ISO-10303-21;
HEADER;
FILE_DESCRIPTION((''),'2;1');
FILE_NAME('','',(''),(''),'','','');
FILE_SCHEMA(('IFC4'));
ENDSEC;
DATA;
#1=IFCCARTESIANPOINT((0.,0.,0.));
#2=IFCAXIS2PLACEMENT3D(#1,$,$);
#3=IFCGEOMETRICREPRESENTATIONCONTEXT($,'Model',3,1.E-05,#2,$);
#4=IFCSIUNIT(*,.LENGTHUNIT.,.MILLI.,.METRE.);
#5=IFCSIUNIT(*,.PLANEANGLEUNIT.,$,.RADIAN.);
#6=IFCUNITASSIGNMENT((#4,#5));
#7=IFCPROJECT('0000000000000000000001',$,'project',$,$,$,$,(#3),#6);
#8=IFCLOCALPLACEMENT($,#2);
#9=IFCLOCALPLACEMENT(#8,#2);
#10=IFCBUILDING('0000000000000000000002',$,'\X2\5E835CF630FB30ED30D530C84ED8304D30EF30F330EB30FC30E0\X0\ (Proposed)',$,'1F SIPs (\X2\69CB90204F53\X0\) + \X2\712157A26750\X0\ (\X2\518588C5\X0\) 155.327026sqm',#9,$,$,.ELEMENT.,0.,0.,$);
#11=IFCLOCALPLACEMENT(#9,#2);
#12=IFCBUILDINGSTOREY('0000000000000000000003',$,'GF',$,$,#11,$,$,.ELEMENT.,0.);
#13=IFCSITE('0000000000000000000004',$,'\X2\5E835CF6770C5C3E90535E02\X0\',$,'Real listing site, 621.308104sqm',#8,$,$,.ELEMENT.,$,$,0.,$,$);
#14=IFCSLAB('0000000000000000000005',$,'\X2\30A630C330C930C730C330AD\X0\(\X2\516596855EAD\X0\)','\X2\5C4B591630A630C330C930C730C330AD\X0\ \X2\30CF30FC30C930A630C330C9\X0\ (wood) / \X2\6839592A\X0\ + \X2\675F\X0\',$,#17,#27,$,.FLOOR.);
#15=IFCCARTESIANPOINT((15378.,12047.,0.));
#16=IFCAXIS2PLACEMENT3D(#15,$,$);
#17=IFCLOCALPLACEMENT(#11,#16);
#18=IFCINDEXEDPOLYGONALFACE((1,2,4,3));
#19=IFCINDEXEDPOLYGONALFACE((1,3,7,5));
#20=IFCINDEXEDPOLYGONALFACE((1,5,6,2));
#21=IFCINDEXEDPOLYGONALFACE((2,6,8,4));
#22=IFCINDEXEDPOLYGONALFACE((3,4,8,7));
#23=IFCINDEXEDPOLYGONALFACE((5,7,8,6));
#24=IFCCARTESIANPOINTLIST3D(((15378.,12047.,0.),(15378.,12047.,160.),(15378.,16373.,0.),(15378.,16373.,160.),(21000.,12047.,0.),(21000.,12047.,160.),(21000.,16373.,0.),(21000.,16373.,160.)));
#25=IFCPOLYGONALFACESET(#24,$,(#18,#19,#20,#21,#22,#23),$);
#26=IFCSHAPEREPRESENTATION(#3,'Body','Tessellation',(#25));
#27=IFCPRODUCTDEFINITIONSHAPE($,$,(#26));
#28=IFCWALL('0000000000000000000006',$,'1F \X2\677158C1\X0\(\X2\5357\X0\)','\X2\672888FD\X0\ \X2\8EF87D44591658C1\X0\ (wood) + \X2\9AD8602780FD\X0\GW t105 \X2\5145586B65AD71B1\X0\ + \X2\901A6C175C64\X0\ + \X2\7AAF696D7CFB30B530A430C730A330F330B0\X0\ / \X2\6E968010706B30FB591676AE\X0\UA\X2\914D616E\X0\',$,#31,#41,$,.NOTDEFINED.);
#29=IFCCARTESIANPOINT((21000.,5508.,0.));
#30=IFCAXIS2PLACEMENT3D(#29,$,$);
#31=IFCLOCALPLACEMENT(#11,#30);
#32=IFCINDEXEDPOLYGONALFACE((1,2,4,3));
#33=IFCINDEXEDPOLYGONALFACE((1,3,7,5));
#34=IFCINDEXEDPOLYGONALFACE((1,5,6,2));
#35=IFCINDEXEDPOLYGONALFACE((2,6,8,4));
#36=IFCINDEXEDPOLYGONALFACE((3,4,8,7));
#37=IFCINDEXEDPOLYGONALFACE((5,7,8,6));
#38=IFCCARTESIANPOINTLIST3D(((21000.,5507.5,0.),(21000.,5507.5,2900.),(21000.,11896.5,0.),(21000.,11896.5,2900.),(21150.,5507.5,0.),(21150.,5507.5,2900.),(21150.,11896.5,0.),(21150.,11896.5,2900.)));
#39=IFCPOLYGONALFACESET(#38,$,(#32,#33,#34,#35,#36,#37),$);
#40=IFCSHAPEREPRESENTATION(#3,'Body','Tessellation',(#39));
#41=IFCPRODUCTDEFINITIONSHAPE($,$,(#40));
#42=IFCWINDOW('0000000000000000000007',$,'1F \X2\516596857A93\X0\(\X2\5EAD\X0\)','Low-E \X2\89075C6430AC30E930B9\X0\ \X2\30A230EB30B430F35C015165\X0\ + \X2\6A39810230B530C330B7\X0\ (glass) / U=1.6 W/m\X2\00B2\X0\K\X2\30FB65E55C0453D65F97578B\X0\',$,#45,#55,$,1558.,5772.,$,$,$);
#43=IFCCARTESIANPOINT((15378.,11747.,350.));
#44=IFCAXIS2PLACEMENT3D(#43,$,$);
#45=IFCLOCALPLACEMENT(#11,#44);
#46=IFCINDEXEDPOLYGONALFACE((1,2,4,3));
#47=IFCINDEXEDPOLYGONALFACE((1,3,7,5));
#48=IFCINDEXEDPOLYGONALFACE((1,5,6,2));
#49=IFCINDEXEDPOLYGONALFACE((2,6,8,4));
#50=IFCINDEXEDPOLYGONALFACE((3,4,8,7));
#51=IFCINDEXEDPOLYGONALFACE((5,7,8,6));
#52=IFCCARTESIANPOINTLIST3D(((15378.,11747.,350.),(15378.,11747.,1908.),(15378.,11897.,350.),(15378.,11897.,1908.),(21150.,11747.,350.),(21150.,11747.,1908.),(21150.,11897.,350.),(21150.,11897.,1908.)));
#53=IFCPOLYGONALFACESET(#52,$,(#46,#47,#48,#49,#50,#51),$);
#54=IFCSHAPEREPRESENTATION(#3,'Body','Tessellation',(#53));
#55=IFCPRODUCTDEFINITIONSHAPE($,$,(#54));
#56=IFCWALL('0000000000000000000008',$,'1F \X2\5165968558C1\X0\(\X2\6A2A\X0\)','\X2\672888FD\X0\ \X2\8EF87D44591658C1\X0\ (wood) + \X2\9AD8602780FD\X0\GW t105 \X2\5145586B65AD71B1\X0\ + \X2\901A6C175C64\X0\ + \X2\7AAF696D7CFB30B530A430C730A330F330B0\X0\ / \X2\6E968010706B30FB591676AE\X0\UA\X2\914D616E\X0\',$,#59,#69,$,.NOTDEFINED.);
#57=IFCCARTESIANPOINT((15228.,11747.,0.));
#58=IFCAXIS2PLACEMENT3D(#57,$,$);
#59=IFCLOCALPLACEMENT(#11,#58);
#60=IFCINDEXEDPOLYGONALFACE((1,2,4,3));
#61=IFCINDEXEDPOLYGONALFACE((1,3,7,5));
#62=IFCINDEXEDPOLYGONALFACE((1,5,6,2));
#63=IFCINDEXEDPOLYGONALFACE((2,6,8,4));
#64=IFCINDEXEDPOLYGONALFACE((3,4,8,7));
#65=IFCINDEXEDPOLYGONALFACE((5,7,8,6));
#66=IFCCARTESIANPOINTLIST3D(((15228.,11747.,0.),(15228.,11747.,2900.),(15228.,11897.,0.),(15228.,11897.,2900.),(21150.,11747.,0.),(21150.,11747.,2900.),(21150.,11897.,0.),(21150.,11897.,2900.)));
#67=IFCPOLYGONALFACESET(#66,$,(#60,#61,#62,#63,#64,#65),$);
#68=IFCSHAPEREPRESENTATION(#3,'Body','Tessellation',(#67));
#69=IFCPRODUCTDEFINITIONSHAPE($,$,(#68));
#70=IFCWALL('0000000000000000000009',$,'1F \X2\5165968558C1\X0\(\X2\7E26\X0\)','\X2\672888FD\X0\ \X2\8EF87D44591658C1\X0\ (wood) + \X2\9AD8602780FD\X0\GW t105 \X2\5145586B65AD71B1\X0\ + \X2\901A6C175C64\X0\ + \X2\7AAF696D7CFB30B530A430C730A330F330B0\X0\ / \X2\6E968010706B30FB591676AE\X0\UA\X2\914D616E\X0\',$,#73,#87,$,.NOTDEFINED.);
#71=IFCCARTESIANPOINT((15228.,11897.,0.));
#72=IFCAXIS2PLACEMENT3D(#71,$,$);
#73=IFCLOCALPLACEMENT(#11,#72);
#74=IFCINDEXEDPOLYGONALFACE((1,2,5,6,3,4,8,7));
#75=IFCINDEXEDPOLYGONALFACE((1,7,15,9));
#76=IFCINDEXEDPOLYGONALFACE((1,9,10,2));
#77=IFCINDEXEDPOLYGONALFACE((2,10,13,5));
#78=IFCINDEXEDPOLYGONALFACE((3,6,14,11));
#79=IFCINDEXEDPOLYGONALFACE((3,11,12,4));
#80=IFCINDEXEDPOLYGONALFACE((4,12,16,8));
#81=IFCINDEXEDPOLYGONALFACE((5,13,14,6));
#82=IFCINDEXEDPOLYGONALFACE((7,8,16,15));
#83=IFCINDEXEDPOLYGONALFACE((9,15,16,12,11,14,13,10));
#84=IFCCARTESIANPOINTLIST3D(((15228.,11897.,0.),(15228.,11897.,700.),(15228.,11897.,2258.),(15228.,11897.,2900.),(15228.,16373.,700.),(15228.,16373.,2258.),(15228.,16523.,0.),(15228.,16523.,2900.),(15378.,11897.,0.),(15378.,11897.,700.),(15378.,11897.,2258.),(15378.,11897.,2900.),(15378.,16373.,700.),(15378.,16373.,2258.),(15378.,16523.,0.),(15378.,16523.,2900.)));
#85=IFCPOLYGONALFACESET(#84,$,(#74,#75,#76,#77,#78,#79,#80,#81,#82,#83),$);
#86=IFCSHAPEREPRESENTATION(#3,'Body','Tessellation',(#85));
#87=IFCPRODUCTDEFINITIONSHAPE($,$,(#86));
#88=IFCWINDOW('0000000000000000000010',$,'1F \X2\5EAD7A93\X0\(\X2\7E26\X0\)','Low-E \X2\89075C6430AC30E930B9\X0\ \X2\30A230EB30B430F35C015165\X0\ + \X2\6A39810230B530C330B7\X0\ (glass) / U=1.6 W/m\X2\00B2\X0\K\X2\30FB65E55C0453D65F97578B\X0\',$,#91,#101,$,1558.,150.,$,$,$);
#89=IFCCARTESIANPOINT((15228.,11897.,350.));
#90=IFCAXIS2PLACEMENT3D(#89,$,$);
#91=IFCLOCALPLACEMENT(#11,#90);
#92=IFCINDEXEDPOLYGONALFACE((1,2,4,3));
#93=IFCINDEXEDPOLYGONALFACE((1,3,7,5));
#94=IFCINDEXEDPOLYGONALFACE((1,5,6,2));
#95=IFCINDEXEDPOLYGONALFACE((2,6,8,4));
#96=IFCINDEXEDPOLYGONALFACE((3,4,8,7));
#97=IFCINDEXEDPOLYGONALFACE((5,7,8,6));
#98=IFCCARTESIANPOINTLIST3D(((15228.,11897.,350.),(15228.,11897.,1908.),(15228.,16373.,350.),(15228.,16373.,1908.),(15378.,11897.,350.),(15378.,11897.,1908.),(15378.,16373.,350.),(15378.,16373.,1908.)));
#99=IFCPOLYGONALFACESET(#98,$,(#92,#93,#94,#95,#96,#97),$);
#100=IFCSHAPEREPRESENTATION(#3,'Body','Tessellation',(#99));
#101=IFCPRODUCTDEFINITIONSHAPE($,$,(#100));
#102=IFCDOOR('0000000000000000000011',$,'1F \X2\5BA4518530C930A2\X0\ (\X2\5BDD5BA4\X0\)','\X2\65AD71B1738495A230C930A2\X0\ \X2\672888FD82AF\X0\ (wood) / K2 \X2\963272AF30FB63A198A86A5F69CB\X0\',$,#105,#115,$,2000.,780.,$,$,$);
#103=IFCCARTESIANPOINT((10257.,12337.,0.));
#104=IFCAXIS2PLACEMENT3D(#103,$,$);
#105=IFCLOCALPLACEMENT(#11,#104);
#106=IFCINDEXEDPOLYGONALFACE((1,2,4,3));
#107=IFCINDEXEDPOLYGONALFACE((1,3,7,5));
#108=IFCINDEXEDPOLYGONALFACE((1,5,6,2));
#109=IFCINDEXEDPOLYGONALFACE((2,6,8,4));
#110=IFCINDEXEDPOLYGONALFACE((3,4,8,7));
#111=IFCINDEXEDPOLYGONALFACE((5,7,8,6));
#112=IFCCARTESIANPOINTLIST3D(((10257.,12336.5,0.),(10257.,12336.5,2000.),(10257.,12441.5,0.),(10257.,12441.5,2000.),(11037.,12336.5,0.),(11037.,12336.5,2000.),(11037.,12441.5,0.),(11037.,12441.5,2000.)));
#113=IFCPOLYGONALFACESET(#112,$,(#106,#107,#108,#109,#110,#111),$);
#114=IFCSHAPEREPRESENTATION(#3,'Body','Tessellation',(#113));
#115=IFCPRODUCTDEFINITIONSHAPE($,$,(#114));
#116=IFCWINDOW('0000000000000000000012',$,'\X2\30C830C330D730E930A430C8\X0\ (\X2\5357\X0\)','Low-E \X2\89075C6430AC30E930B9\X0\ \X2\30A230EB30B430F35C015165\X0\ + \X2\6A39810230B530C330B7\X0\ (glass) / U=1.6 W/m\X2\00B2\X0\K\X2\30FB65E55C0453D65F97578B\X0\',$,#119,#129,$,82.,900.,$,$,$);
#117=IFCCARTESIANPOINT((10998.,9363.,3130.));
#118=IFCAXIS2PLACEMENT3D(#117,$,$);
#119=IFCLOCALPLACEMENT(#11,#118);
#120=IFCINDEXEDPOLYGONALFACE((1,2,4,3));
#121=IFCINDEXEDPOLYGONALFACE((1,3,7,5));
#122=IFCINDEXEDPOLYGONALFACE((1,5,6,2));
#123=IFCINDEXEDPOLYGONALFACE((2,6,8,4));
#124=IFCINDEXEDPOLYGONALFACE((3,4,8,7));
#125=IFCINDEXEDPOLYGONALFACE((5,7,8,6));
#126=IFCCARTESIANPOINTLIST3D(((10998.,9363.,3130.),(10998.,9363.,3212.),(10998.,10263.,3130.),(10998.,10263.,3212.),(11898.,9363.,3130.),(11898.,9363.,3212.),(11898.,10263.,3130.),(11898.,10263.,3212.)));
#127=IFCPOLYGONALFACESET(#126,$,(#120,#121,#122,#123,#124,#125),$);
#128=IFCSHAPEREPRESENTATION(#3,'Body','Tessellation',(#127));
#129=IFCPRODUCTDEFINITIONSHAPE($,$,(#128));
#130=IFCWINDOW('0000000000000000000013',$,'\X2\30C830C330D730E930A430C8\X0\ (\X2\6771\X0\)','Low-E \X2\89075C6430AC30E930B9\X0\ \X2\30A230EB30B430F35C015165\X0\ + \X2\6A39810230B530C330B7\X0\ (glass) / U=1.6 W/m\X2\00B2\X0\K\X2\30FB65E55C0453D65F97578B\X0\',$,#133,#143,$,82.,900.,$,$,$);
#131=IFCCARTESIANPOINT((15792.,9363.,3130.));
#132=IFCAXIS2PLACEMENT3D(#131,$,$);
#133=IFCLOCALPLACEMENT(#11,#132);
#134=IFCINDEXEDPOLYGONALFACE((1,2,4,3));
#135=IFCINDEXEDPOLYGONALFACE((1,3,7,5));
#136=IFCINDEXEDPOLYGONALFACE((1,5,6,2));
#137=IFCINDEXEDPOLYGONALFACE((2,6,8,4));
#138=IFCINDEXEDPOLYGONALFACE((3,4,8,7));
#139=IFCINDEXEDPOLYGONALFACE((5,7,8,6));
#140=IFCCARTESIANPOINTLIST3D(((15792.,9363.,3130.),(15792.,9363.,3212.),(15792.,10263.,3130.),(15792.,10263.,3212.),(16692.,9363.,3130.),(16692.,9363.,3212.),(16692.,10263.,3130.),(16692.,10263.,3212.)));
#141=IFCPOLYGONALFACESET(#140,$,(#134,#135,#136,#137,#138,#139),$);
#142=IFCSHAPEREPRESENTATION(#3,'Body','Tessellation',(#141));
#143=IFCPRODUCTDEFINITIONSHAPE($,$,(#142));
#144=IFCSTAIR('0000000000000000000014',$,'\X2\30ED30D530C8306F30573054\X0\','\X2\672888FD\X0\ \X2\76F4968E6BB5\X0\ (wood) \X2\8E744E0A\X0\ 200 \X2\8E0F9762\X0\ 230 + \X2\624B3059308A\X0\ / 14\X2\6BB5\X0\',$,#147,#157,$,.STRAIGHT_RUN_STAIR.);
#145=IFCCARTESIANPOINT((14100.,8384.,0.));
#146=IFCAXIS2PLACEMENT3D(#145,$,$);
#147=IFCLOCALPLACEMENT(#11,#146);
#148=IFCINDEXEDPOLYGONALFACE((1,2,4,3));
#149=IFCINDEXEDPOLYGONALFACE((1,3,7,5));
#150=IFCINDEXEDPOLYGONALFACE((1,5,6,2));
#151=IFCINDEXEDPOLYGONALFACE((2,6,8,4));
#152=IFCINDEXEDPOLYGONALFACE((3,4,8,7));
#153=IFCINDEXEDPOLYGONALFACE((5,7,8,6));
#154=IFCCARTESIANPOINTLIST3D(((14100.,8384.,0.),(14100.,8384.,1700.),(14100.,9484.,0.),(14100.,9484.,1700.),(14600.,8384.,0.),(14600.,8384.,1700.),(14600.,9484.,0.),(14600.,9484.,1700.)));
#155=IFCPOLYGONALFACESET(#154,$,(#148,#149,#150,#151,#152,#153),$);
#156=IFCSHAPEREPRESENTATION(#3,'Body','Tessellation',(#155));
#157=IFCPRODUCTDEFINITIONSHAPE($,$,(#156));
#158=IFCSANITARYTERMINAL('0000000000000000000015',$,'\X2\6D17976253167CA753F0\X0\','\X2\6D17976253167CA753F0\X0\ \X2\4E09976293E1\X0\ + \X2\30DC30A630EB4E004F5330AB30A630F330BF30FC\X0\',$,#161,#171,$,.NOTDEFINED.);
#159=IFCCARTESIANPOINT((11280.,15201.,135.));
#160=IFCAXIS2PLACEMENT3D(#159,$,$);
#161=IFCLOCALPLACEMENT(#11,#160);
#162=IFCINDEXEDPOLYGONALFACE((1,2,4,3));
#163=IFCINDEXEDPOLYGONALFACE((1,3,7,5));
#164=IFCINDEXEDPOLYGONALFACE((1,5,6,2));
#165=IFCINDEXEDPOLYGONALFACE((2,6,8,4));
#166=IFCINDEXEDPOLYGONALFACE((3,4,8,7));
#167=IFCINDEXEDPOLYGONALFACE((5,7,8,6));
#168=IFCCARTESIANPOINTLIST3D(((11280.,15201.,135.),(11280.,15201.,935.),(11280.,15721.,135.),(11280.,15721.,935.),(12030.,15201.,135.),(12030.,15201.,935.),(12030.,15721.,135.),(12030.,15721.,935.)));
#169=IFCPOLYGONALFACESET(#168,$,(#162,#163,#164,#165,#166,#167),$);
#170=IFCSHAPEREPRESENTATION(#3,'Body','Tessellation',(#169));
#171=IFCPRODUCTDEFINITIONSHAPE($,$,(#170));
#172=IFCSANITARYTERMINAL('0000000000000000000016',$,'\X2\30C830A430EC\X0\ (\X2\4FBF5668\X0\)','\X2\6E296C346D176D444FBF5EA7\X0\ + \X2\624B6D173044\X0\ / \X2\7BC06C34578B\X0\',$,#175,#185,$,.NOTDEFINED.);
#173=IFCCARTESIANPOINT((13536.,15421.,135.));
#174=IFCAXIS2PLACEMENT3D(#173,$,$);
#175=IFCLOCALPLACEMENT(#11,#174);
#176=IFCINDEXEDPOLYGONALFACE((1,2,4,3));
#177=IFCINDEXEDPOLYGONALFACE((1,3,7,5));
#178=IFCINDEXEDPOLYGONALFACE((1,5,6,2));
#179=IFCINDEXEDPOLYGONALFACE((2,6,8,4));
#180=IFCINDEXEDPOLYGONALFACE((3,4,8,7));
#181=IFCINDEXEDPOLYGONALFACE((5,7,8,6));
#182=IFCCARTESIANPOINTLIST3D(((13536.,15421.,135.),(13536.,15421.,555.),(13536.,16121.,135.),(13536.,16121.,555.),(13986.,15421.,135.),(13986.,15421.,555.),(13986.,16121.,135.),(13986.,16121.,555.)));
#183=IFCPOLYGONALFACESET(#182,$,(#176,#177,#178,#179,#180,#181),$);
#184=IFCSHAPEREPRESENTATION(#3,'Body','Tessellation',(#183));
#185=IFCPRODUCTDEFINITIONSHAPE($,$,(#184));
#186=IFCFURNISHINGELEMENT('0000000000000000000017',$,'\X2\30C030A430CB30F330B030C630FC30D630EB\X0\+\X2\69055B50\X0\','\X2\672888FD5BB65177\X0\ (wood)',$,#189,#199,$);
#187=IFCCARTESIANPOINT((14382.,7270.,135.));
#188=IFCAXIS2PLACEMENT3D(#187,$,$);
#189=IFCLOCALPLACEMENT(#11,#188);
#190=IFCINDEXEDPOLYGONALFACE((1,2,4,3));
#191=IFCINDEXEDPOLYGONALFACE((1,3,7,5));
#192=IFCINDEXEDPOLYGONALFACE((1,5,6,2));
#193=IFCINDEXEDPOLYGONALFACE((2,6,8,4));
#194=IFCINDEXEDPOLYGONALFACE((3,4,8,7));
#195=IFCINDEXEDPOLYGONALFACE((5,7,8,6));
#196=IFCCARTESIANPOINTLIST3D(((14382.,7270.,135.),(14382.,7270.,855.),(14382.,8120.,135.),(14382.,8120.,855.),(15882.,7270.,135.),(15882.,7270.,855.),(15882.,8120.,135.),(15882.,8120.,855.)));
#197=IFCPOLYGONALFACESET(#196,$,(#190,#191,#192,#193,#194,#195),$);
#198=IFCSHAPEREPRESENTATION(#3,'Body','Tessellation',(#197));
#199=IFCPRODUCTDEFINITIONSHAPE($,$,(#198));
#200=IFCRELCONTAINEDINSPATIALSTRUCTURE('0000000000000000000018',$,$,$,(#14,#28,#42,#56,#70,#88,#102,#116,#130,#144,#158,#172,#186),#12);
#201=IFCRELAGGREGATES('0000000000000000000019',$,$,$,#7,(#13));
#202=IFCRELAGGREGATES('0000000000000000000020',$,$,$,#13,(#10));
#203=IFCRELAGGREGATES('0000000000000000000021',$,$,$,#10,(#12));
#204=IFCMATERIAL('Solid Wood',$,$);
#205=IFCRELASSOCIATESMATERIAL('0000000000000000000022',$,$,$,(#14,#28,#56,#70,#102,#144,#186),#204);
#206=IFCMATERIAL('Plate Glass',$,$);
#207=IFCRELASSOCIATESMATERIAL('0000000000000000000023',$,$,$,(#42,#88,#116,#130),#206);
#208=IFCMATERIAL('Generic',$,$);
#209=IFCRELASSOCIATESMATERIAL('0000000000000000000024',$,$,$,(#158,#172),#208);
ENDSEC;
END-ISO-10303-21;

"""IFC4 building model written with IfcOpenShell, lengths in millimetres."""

from ifc_helpers import new_model, si_unit, frame, frame_2d, origin, place, context, project, spatial, rectangle, extrude, material, element, fill, save


model = new_model("IFC4")

# Units and contexts
model_context = context("Model", 3, precision=1e-05, world=origin())
ifc_project = project(units=[si_unit("LENGTHUNIT", "METRE", prefix="MILLI"), si_unit("PLANEANGLEUNIT", "RADIAN")], contexts=[model_context])

# Site, building, storey
site_placement = place(None, origin())
site = spatial("IfcSite", under=ifc_project, at=site_placement, Name="広島県尾道市", ObjectType="Real listing site, 621.308104sqm", CompositionType="ELEMENT", RefElevation=0.0)
building_placement = place(site_placement, origin())
building = spatial("IfcBuilding", under=site, at=building_placement, Name="広島・ロフト付きワンルーム (Proposed)", ObjectType="1F SIPs (構造体) + 無垢材 (内装) 155.327026sqm", CompositionType="ELEMENT", ElevationOfRefHeight=0.0, ElevationOfTerrain=0.0)
storey_placement = place(building_placement, origin())
storey = spatial("IfcBuildingStorey", under=building, at=storey_placement, Name="GF", CompositionType="ELEMENT", Elevation=0.0)

# Slab
ifc_material_1 = material(Name="Solid Wood")
slab_placement = place(storey_placement, frame((15378.0, 12047.0, 0.0)))
element("IfcSlab", 1, at=slab_placement, inside=storey, material=ifc_material_1, Name="ウッドデッキ(入隅庭)", Description="屋外ウッドデッキ ハードウッド (wood) / 根太 + 束", PredefinedType="FLOOR", context=model_context, shape_type="SweptSolid", body=[
    extrude(rectangle(XDim=5622.0, YDim=4326.0, at=frame_2d((2811.0, 2163.0))), frame((15378.0, 12047.0, 0.0)), (0.0, 0.0, 1.0), 160.0),
])

# Wall, opening, window
wall_1_placement = place(storey_placement, frame((21000.0, 5508.0, 0.0)))
wall_1 = element("IfcWall", 2, at=wall_1_placement, inside=storey, material=ifc_material_1, Name="1F 東壁(南)", Description="木製 軸組外壁 (wood) + 高性能GW t105 充填断熱 + 通気層 + 窯業系サイディング / 準耐火・外皮UA配慮", PredefinedType="NOTDEFINED", context=model_context, shape_type="SweptSolid", body=[
    extrude(rectangle(XDim=150.0, YDim=6389.0, at=frame_2d((75.0, 3194.0))), frame((21000.0, 5508.0, 0.0)), (0.0, 0.0, 1.0), 2900.0),
])
opening_1_placement = place(storey_placement, frame((15378.0, 11747.0, 350.0)))
opening_1 = element("IfcOpeningElement", 3, at=opening_1_placement, cuts=wall_1, PredefinedType="NOTDEFINED", context=model_context, shape_type="SweptSolid", body=[
    extrude(rectangle(XDim=5772.0, YDim=150.0, at=frame_2d((2886.0, 75.0))), frame((15378.0, 11747.0, 350.0)), (0.0, 0.0, 1.0), 1558.0),
])
ifc_material_2 = material(Name="Plate Glass")
window_1_placement = place(storey_placement, frame((15378.0, 11747.0, 350.0)))
window_1 = element("IfcWindow", 4, at=window_1_placement, inside=storey, material=ifc_material_2, Name="1F 入隅窓(庭)", Description="Low-E 複層ガラス アルゴン封入 + 樹脂サッシ (glass) / U=1.6 W/m²K・日射取得型", OverallHeight=1558.0, OverallWidth=5772.0, context=model_context, shape_type="SweptSolid", body=[
    extrude(rectangle(XDim=5772.0, YDim=150.0, at=frame_2d((2886.0, 75.0))), frame((15378.0, 11747.0, 350.0)), (0.0, 0.0, 1.0), 1558.0),
])
fill(opening_1, window_1)

# Wall
wall_2_placement = place(storey_placement, frame((15228.0, 11747.0, 0.0)))
element("IfcWall", 5, at=wall_2_placement, inside=storey, material=ifc_material_1, Name="1F 入隅壁(横)", Description="木製 軸組外壁 (wood) + 高性能GW t105 充填断熱 + 通気層 + 窯業系サイディング / 準耐火・外皮UA配慮", PredefinedType="NOTDEFINED", context=model_context, shape_type="SweptSolid", body=[
    extrude(rectangle(XDim=5922.0, YDim=150.0, at=frame_2d((2961.0, 75.0))), frame((15228.0, 11747.0, 0.0)), (0.0, 0.0, 1.0), 2900.0),
])

# Wall, opening, window
wall_3_placement = place(storey_placement, frame((15228.0, 11897.0, 0.0)))
wall_3 = element("IfcWall", 6, at=wall_3_placement, inside=storey, material=ifc_material_1, Name="1F 入隅壁(縦)", Description="木製 軸組外壁 (wood) + 高性能GW t105 充填断熱 + 通気層 + 窯業系サイディング / 準耐火・外皮UA配慮", PredefinedType="NOTDEFINED", context=model_context, shape_type="SweptSolid", body=[
    extrude(rectangle(XDim=150.0, YDim=4626.0, at=frame_2d((75.0, 2313.0))), frame((15228.0, 11897.0, 0.0)), (0.0, 0.0, 1.0), 2900.0),
])
opening_2_placement = place(storey_placement, frame((15228.0, 11897.0, 350.0)))
opening_2 = element("IfcOpeningElement", 7, at=opening_2_placement, cuts=wall_3, PredefinedType="NOTDEFINED", context=model_context, shape_type="SweptSolid", body=[
    extrude(rectangle(XDim=150.0, YDim=4476.0, at=frame_2d((75.0, 2238.0))), frame((15228.0, 11897.0, 350.0)), (0.0, 0.0, 1.0), 1558.0),
])
window_2_placement = place(storey_placement, frame((15228.0, 11897.0, 350.0)))
window_2 = element("IfcWindow", 8, at=window_2_placement, inside=storey, material=ifc_material_2, Name="1F 庭窓(縦)", Description="Low-E 複層ガラス アルゴン封入 + 樹脂サッシ (glass) / U=1.6 W/m²K・日射取得型", OverallHeight=1558.0, OverallWidth=150.0, context=model_context, shape_type="SweptSolid", body=[
    extrude(rectangle(XDim=150.0, YDim=4476.0, at=frame_2d((75.0, 2238.0))), frame((15228.0, 11897.0, 350.0)), (0.0, 0.0, 1.0), 1558.0),
])
fill(opening_2, window_2)

# Door
door_placement = place(storey_placement, frame((10257.0, 12337.0, 0.0)))
element("IfcDoor", 9, at=door_placement, inside=storey, material=ifc_material_1, Name="1F 室内ドア (寝室)", Description="断熱玄関ドア 木製芯 (wood) / K2 防犯・採風機構", OverallHeight=2000.0, OverallWidth=780.0, context=model_context, shape_type="SweptSolid", body=[
    extrude(rectangle(XDim=780.0, YDim=105.0, at=frame_2d((390.0, 52.0))), frame((10257.0, 12337.0, 0.0)), (0.0, 0.0, 1.0), 2000.0),
])

# Windows
window_3_placement = place(storey_placement, frame((10998.0, 9363.0, 3130.0)))
element("IfcWindow", 10, at=window_3_placement, inside=storey, material=ifc_material_2, Name="トップライト (南)", Description="Low-E 複層ガラス アルゴン封入 + 樹脂サッシ (glass) / U=1.6 W/m²K・日射取得型", OverallHeight=82.0, OverallWidth=900.0, context=model_context, shape_type="SweptSolid", body=[
    extrude(rectangle(XDim=900.0, YDim=900.0, at=frame_2d((450.0, 450.0))), frame((10998.0, 9363.0, 3130.0)), (0.0, 0.0, 1.0), 82.0),
])
window_4_placement = place(storey_placement, frame((15792.0, 9363.0, 3130.0)))
element("IfcWindow", 11, at=window_4_placement, inside=storey, material=ifc_material_2, Name="トップライト (東)", Description="Low-E 複層ガラス アルゴン封入 + 樹脂サッシ (glass) / U=1.6 W/m²K・日射取得型", OverallHeight=82.0, OverallWidth=900.0, context=model_context, shape_type="SweptSolid", body=[
    extrude(rectangle(XDim=900.0, YDim=900.0, at=frame_2d((450.0, 450.0))), frame((15792.0, 9363.0, 3130.0)), (0.0, 0.0, 1.0), 82.0),
])

# Stair
stair_placement = place(storey_placement, frame((14100.0, 8384.0, 0.0)))
element("IfcStair", 12, at=stair_placement, inside=storey, material=ifc_material_1, Name="ロフトはしご", Description="木製 直階段 (wood) 蹴上 200 踏面 230 + 手すり / 14段", PredefinedType="STRAIGHT_RUN_STAIR", context=model_context, shape_type="SweptSolid", body=[
    extrude(rectangle(XDim=500.0, YDim=1100.0, at=frame_2d((250.0, 550.0))), frame((14100.0, 8384.0, 0.0)), (0.0, 0.0, 1.0), 1700.0),
])

# Sanitary terminals
ifc_material_3 = material(Name="Generic")
sanitary_terminal_1_placement = place(storey_placement, frame((11280.0, 15201.0, 135.0)))
element("IfcSanitaryTerminal", 13, at=sanitary_terminal_1_placement, inside=storey, material=ifc_material_3, Name="洗面化粧台", Description="洗面化粧台 三面鏡 + ボウル一体カウンター", PredefinedType="NOTDEFINED", context=model_context, shape_type="SweptSolid", body=[
    extrude(rectangle(XDim=750.0, YDim=520.0, at=frame_2d((375.0, 260.0))), frame((11280.0, 15201.0, 135.0)), (0.0, 0.0, 1.0), 800.0),
])
sanitary_terminal_2_placement = place(storey_placement, frame((13536.0, 15421.0, 135.0)))
element("IfcSanitaryTerminal", 14, at=sanitary_terminal_2_placement, inside=storey, material=ifc_material_3, Name="トイレ (便器)", Description="温水洗浄便座 + 手洗い / 節水型", PredefinedType="NOTDEFINED", context=model_context, shape_type="SweptSolid", body=[
    extrude(rectangle(XDim=450.0, YDim=700.0, at=frame_2d((225.0, 350.0))), frame((13536.0, 15421.0, 135.0)), (0.0, 0.0, 1.0), 420.0),
])

# Furnishing element
furnishing_1_placement = place(storey_placement, frame((14382.0, 7270.0, 135.0)))
element("IfcFurnishingElement", 15, at=furnishing_1_placement, inside=storey, material=ifc_material_1, Name="ダイニングテーブル+椅子", Description="木製家具 (wood)", context=model_context, shape_type="SweptSolid", body=[
    extrude(rectangle(XDim=1500.0, YDim=850.0, at=frame_2d((750.0, 425.0))), frame((14382.0, 7270.0, 135.0)), (0.0, 0.0, 1.0), 720.0),
])

save(model, "model.ifc")
